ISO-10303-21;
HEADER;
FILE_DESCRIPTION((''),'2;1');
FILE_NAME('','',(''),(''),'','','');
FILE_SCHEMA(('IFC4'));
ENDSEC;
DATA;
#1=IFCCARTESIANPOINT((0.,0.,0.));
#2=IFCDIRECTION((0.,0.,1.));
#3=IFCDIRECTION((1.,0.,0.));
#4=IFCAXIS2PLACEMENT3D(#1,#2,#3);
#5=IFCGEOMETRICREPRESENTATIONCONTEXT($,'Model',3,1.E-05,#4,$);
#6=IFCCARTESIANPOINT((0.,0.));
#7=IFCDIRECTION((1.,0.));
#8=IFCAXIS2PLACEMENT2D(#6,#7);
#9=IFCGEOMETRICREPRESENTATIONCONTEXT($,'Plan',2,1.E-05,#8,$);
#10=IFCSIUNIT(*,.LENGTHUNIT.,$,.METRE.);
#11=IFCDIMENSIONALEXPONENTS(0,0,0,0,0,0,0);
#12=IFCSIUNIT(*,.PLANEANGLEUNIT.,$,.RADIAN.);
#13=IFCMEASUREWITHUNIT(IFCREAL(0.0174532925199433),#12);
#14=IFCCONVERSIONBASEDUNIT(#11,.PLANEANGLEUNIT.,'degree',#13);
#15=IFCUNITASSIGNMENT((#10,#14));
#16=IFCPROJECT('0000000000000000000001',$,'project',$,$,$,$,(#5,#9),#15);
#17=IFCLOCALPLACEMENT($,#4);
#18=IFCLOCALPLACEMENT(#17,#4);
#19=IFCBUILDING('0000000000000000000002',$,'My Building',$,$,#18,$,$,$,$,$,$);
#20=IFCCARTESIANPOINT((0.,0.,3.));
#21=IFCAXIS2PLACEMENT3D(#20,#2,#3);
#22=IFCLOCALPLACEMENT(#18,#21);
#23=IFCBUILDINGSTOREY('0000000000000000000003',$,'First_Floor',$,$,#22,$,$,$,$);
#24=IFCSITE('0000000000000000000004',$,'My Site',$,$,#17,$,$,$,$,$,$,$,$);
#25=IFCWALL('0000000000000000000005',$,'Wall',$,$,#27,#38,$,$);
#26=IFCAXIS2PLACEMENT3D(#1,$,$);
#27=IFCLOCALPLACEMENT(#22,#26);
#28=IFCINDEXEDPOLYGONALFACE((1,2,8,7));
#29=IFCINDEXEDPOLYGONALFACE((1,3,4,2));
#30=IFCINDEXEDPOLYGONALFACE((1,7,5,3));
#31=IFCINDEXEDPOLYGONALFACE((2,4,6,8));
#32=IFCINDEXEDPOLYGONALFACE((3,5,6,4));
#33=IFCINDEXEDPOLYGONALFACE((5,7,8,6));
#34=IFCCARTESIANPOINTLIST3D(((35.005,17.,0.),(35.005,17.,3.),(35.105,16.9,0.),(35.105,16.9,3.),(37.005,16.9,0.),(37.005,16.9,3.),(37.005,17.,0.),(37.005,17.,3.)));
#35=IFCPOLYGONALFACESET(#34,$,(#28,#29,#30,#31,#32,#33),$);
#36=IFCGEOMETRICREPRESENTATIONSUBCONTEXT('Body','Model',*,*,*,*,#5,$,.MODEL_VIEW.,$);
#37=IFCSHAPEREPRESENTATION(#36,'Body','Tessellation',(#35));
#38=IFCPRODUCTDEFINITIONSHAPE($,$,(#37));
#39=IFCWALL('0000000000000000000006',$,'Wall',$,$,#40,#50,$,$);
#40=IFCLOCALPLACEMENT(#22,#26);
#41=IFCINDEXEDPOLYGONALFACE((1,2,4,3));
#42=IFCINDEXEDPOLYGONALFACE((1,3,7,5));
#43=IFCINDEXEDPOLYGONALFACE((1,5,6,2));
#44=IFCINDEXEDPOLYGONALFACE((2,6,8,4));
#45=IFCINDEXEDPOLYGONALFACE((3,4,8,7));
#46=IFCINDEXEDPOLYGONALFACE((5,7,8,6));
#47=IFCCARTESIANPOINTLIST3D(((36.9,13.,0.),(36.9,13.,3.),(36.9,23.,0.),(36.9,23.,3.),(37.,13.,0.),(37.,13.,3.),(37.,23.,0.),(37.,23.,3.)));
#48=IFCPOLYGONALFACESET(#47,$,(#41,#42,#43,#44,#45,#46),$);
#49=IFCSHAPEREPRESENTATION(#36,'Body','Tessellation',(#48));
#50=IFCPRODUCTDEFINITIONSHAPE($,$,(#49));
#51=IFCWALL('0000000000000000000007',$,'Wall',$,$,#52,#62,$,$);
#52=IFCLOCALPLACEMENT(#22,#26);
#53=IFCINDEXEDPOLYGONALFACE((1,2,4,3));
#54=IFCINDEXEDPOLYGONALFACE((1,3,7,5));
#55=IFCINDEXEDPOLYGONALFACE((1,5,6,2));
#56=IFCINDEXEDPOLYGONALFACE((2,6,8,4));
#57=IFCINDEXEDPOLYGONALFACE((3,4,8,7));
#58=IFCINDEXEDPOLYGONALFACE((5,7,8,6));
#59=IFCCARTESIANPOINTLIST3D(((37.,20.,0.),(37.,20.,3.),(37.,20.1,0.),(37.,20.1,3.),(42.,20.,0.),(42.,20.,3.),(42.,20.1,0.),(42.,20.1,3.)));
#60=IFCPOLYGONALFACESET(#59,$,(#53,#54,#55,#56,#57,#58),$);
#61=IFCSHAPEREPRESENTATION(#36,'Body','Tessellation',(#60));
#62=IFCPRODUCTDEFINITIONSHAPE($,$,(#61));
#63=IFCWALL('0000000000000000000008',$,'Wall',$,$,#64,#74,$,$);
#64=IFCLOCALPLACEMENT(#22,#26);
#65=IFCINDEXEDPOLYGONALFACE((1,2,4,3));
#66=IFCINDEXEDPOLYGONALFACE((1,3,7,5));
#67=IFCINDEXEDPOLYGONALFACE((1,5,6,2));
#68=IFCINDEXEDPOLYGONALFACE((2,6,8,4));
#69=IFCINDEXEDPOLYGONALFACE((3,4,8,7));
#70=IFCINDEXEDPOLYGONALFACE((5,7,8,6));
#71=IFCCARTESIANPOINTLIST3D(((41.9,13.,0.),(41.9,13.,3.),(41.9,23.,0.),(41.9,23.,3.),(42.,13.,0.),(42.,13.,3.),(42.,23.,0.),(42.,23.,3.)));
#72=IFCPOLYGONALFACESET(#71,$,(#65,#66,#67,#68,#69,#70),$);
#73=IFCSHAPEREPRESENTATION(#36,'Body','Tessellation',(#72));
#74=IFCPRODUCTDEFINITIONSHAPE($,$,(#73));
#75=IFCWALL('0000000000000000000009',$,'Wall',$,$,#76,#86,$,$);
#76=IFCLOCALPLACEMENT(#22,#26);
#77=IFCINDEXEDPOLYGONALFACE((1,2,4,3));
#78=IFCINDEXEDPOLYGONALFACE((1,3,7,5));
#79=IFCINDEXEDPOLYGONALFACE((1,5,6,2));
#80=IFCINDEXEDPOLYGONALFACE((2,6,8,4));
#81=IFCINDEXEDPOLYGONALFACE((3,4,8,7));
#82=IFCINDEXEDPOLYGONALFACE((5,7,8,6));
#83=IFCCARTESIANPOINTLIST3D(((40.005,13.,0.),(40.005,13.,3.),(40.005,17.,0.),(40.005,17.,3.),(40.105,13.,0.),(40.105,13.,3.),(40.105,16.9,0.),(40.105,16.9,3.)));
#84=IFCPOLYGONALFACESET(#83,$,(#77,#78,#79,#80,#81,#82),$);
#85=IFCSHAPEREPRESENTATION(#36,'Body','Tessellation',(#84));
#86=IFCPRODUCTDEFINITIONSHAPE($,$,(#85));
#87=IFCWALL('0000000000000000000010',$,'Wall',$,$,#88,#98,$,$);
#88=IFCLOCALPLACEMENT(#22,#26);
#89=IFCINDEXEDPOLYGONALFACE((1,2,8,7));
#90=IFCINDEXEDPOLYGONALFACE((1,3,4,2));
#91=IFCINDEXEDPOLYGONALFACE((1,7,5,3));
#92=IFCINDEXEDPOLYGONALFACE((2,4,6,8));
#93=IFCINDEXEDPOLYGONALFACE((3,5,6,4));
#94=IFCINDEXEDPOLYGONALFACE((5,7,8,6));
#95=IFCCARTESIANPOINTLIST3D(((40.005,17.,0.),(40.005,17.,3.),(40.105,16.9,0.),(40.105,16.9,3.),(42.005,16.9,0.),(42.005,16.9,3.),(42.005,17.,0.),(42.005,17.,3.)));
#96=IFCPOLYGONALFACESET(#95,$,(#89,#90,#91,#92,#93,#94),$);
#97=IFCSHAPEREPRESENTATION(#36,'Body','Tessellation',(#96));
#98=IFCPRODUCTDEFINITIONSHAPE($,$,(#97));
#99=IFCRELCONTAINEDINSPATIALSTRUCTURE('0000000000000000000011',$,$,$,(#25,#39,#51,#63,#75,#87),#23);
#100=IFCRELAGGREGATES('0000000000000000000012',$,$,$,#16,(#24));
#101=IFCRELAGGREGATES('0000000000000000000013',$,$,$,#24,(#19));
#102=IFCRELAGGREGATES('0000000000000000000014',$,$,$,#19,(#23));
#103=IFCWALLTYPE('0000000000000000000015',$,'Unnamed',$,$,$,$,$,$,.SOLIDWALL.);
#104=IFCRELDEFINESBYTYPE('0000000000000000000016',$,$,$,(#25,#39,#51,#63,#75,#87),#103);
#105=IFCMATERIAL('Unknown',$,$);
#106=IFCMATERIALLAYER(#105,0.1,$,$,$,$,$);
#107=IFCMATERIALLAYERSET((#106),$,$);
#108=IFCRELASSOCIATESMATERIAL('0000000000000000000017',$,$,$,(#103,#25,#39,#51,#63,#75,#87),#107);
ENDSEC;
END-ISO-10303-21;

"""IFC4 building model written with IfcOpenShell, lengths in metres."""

from ifc_helpers import new_model, entity, si_unit, converted_unit, frame, origin_with_axes, origin_2d_with_axis, place, context, subcontext, project, spatial, line, indexed_curve, outline, extrude, material, layer, layer_set, layer_usage, type_object, element, save


model = new_model("IFC4")

# Units and contexts
model_context = context("Model", 3, precision=1e-05, world=origin_with_axes())
plan_context = context("Plan", 2, precision=1e-05, world=origin_2d_with_axis())
body_context = subcontext(model_context, "Body", "Model", "MODEL_VIEW")
ifc_project = project(units=[si_unit("LENGTHUNIT", "METRE"), converted_unit("PLANEANGLEUNIT", "degree", entity("IfcReal", 0.0174532925199433), si_unit("PLANEANGLEUNIT", "RADIAN"), dimensions=[0, 0, 0, 0, 0, 0, 0])], contexts=[model_context, plan_context])

# Site, building, storey
site_placement = place(None, origin_with_axes())
site = spatial("IfcSite", under=ifc_project, at=site_placement, Name="My Site")
building_placement = place(site_placement, origin_with_axes())
building = spatial("IfcBuilding", under=site, at=building_placement, Name="My Building")
storey_placement = place(building_placement, frame((0.0, 0.0, 3.0), z_axis=(0.0, 0.0, 1.0), x_axis=(1.0, 0.0, 0.0)))
storey = spatial("IfcBuildingStorey", under=building, at=storey_placement, Name="First_Floor")

# Walls
ifc_material = material(Name="Unknown")
ifc_layer = layer(ifc_material, 0.1)
ifc_layer_set = layer_set([ifc_layer])
wall_type = type_object("IfcWallType", Name="Unnamed", PredefinedType="SOLIDWALL", material=ifc_layer_set)
ifc_layer_usage_1 = layer_usage(ifc_layer_set, "AXIS2", "POSITIVE", 0.0)
wall_1_placement = place(storey_placement, frame((37.005, 17.0, 0.0), z_axis=(0.0, 0.0, 1.0), x_axis=(-1.0, 0.0, 0.0)))
element("IfcWall", 1, at=wall_1_placement, inside=storey, type_object=wall_type, material=ifc_layer_usage_1, Name="Wall", context=body_context, shape_type="SweptSolid", body=[
    extrude(outline(indexed_curve([(0.0, 0.0), (0.0, 0.1), (1.9, 0.1), (2.0, 0.0)], segments=[line(1, 2, 3, 4, 1)])), origin_with_axes(), (0.0, 0.0, 1.0), 3.0),
])
ifc_layer_usage_2 = layer_usage(ifc_layer_set, "AXIS2", "POSITIVE", 0.0)
wall_2_placement = place(storey_placement, frame((36.9, 23.0, 0.0), z_axis=(0.0, 0.0, 1.0), x_axis=(0.0, -1.0, 0.0)))
element("IfcWall", 2, at=wall_2_placement, inside=storey, type_object=wall_type, material=ifc_layer_usage_2, Name="Wall", context=body_context, shape_type="SweptSolid", body=[
    extrude(outline(indexed_curve([(0.0, 0.0), (0.0, 0.1), (10.0, 0.1), (10.0, 0.0)], segments=[line(1, 2, 3, 4, 1)])), origin_with_axes(), (0.0, 0.0, 1.0), 3.0),
])
ifc_layer_usage_3 = layer_usage(ifc_layer_set, "AXIS2", "POSITIVE", 0.0)
wall_3_placement = place(storey_placement, frame((37.0, 20.0, 0.0), z_axis=(0.0, 0.0, 1.0), x_axis=(1.0, 0.0, 0.0)))
element("IfcWall", 3, at=wall_3_placement, inside=storey, type_object=wall_type, material=ifc_layer_usage_3, Name="Wall", context=body_context, shape_type="SweptSolid", body=[
    extrude(outline(indexed_curve([(0.0, 0.0), (0.0, 0.1), (5.0, 0.1), (5.0, 0.0)], segments=[line(1, 2, 3, 4, 1)])), origin_with_axes(), (0.0, 0.0, 1.0), 3.0),
])
ifc_layer_usage_4 = layer_usage(ifc_layer_set, "AXIS2", "POSITIVE", 0.0)
wall_4_placement = place(storey_placement, frame((41.9, 23.0, 0.0), z_axis=(0.0, 0.0, 1.0), x_axis=(0.0, -1.0, 0.0)))
element("IfcWall", 4, at=wall_4_placement, inside=storey, type_object=wall_type, material=ifc_layer_usage_4, Name="Wall", context=body_context, shape_type="SweptSolid", body=[
    extrude(outline(indexed_curve([(0.0, 0.0), (0.0, 0.1), (10.0, 0.1), (10.0, 0.0)], segments=[line(1, 2, 3, 4, 1)])), origin_with_axes(), (0.0, 0.0, 1.0), 3.0),
])
ifc_layer_usage_5 = layer_usage(ifc_layer_set, "AXIS2", "POSITIVE", 0.0)
wall_5_placement = place(storey_placement, frame((40.005, 17.0, 0.0), z_axis=(0.0, 0.0, 1.0), x_axis=(0.0, -1.0, 0.0)))
element("IfcWall", 5, at=wall_5_placement, inside=storey, type_object=wall_type, material=ifc_layer_usage_5, Name="Wall", context=body_context, shape_type="SweptSolid", body=[
    extrude(outline(indexed_curve([(0.0, 0.0), (0.1, 0.1), (4.0, 0.1), (4.0, 0.0)], segments=[line(1, 2, 3, 4, 1)])), origin_with_axes(), (0.0, 0.0, 1.0), 3.0),
])
ifc_layer_usage_6 = layer_usage(ifc_layer_set, "AXIS2", "POSITIVE", 0.0)
wall_6_placement = place(storey_placement, frame((42.005, 17.0, 0.0), z_axis=(0.0, 0.0, 1.0), x_axis=(-1.0, 0.0, 0.0)))
element("IfcWall", 6, at=wall_6_placement, inside=storey, type_object=wall_type, material=ifc_layer_usage_6, Name="Wall", context=body_context, shape_type="SweptSolid", body=[
    extrude(outline(indexed_curve([(0.0, 0.0), (0.0, 0.1), (1.9, 0.1), (2.0, 0.0)], segments=[line(1, 2, 3, 4, 1)])), origin_with_axes(), (0.0, 0.0, 1.0), 3.0),
])

save(model, "model.ifc")
